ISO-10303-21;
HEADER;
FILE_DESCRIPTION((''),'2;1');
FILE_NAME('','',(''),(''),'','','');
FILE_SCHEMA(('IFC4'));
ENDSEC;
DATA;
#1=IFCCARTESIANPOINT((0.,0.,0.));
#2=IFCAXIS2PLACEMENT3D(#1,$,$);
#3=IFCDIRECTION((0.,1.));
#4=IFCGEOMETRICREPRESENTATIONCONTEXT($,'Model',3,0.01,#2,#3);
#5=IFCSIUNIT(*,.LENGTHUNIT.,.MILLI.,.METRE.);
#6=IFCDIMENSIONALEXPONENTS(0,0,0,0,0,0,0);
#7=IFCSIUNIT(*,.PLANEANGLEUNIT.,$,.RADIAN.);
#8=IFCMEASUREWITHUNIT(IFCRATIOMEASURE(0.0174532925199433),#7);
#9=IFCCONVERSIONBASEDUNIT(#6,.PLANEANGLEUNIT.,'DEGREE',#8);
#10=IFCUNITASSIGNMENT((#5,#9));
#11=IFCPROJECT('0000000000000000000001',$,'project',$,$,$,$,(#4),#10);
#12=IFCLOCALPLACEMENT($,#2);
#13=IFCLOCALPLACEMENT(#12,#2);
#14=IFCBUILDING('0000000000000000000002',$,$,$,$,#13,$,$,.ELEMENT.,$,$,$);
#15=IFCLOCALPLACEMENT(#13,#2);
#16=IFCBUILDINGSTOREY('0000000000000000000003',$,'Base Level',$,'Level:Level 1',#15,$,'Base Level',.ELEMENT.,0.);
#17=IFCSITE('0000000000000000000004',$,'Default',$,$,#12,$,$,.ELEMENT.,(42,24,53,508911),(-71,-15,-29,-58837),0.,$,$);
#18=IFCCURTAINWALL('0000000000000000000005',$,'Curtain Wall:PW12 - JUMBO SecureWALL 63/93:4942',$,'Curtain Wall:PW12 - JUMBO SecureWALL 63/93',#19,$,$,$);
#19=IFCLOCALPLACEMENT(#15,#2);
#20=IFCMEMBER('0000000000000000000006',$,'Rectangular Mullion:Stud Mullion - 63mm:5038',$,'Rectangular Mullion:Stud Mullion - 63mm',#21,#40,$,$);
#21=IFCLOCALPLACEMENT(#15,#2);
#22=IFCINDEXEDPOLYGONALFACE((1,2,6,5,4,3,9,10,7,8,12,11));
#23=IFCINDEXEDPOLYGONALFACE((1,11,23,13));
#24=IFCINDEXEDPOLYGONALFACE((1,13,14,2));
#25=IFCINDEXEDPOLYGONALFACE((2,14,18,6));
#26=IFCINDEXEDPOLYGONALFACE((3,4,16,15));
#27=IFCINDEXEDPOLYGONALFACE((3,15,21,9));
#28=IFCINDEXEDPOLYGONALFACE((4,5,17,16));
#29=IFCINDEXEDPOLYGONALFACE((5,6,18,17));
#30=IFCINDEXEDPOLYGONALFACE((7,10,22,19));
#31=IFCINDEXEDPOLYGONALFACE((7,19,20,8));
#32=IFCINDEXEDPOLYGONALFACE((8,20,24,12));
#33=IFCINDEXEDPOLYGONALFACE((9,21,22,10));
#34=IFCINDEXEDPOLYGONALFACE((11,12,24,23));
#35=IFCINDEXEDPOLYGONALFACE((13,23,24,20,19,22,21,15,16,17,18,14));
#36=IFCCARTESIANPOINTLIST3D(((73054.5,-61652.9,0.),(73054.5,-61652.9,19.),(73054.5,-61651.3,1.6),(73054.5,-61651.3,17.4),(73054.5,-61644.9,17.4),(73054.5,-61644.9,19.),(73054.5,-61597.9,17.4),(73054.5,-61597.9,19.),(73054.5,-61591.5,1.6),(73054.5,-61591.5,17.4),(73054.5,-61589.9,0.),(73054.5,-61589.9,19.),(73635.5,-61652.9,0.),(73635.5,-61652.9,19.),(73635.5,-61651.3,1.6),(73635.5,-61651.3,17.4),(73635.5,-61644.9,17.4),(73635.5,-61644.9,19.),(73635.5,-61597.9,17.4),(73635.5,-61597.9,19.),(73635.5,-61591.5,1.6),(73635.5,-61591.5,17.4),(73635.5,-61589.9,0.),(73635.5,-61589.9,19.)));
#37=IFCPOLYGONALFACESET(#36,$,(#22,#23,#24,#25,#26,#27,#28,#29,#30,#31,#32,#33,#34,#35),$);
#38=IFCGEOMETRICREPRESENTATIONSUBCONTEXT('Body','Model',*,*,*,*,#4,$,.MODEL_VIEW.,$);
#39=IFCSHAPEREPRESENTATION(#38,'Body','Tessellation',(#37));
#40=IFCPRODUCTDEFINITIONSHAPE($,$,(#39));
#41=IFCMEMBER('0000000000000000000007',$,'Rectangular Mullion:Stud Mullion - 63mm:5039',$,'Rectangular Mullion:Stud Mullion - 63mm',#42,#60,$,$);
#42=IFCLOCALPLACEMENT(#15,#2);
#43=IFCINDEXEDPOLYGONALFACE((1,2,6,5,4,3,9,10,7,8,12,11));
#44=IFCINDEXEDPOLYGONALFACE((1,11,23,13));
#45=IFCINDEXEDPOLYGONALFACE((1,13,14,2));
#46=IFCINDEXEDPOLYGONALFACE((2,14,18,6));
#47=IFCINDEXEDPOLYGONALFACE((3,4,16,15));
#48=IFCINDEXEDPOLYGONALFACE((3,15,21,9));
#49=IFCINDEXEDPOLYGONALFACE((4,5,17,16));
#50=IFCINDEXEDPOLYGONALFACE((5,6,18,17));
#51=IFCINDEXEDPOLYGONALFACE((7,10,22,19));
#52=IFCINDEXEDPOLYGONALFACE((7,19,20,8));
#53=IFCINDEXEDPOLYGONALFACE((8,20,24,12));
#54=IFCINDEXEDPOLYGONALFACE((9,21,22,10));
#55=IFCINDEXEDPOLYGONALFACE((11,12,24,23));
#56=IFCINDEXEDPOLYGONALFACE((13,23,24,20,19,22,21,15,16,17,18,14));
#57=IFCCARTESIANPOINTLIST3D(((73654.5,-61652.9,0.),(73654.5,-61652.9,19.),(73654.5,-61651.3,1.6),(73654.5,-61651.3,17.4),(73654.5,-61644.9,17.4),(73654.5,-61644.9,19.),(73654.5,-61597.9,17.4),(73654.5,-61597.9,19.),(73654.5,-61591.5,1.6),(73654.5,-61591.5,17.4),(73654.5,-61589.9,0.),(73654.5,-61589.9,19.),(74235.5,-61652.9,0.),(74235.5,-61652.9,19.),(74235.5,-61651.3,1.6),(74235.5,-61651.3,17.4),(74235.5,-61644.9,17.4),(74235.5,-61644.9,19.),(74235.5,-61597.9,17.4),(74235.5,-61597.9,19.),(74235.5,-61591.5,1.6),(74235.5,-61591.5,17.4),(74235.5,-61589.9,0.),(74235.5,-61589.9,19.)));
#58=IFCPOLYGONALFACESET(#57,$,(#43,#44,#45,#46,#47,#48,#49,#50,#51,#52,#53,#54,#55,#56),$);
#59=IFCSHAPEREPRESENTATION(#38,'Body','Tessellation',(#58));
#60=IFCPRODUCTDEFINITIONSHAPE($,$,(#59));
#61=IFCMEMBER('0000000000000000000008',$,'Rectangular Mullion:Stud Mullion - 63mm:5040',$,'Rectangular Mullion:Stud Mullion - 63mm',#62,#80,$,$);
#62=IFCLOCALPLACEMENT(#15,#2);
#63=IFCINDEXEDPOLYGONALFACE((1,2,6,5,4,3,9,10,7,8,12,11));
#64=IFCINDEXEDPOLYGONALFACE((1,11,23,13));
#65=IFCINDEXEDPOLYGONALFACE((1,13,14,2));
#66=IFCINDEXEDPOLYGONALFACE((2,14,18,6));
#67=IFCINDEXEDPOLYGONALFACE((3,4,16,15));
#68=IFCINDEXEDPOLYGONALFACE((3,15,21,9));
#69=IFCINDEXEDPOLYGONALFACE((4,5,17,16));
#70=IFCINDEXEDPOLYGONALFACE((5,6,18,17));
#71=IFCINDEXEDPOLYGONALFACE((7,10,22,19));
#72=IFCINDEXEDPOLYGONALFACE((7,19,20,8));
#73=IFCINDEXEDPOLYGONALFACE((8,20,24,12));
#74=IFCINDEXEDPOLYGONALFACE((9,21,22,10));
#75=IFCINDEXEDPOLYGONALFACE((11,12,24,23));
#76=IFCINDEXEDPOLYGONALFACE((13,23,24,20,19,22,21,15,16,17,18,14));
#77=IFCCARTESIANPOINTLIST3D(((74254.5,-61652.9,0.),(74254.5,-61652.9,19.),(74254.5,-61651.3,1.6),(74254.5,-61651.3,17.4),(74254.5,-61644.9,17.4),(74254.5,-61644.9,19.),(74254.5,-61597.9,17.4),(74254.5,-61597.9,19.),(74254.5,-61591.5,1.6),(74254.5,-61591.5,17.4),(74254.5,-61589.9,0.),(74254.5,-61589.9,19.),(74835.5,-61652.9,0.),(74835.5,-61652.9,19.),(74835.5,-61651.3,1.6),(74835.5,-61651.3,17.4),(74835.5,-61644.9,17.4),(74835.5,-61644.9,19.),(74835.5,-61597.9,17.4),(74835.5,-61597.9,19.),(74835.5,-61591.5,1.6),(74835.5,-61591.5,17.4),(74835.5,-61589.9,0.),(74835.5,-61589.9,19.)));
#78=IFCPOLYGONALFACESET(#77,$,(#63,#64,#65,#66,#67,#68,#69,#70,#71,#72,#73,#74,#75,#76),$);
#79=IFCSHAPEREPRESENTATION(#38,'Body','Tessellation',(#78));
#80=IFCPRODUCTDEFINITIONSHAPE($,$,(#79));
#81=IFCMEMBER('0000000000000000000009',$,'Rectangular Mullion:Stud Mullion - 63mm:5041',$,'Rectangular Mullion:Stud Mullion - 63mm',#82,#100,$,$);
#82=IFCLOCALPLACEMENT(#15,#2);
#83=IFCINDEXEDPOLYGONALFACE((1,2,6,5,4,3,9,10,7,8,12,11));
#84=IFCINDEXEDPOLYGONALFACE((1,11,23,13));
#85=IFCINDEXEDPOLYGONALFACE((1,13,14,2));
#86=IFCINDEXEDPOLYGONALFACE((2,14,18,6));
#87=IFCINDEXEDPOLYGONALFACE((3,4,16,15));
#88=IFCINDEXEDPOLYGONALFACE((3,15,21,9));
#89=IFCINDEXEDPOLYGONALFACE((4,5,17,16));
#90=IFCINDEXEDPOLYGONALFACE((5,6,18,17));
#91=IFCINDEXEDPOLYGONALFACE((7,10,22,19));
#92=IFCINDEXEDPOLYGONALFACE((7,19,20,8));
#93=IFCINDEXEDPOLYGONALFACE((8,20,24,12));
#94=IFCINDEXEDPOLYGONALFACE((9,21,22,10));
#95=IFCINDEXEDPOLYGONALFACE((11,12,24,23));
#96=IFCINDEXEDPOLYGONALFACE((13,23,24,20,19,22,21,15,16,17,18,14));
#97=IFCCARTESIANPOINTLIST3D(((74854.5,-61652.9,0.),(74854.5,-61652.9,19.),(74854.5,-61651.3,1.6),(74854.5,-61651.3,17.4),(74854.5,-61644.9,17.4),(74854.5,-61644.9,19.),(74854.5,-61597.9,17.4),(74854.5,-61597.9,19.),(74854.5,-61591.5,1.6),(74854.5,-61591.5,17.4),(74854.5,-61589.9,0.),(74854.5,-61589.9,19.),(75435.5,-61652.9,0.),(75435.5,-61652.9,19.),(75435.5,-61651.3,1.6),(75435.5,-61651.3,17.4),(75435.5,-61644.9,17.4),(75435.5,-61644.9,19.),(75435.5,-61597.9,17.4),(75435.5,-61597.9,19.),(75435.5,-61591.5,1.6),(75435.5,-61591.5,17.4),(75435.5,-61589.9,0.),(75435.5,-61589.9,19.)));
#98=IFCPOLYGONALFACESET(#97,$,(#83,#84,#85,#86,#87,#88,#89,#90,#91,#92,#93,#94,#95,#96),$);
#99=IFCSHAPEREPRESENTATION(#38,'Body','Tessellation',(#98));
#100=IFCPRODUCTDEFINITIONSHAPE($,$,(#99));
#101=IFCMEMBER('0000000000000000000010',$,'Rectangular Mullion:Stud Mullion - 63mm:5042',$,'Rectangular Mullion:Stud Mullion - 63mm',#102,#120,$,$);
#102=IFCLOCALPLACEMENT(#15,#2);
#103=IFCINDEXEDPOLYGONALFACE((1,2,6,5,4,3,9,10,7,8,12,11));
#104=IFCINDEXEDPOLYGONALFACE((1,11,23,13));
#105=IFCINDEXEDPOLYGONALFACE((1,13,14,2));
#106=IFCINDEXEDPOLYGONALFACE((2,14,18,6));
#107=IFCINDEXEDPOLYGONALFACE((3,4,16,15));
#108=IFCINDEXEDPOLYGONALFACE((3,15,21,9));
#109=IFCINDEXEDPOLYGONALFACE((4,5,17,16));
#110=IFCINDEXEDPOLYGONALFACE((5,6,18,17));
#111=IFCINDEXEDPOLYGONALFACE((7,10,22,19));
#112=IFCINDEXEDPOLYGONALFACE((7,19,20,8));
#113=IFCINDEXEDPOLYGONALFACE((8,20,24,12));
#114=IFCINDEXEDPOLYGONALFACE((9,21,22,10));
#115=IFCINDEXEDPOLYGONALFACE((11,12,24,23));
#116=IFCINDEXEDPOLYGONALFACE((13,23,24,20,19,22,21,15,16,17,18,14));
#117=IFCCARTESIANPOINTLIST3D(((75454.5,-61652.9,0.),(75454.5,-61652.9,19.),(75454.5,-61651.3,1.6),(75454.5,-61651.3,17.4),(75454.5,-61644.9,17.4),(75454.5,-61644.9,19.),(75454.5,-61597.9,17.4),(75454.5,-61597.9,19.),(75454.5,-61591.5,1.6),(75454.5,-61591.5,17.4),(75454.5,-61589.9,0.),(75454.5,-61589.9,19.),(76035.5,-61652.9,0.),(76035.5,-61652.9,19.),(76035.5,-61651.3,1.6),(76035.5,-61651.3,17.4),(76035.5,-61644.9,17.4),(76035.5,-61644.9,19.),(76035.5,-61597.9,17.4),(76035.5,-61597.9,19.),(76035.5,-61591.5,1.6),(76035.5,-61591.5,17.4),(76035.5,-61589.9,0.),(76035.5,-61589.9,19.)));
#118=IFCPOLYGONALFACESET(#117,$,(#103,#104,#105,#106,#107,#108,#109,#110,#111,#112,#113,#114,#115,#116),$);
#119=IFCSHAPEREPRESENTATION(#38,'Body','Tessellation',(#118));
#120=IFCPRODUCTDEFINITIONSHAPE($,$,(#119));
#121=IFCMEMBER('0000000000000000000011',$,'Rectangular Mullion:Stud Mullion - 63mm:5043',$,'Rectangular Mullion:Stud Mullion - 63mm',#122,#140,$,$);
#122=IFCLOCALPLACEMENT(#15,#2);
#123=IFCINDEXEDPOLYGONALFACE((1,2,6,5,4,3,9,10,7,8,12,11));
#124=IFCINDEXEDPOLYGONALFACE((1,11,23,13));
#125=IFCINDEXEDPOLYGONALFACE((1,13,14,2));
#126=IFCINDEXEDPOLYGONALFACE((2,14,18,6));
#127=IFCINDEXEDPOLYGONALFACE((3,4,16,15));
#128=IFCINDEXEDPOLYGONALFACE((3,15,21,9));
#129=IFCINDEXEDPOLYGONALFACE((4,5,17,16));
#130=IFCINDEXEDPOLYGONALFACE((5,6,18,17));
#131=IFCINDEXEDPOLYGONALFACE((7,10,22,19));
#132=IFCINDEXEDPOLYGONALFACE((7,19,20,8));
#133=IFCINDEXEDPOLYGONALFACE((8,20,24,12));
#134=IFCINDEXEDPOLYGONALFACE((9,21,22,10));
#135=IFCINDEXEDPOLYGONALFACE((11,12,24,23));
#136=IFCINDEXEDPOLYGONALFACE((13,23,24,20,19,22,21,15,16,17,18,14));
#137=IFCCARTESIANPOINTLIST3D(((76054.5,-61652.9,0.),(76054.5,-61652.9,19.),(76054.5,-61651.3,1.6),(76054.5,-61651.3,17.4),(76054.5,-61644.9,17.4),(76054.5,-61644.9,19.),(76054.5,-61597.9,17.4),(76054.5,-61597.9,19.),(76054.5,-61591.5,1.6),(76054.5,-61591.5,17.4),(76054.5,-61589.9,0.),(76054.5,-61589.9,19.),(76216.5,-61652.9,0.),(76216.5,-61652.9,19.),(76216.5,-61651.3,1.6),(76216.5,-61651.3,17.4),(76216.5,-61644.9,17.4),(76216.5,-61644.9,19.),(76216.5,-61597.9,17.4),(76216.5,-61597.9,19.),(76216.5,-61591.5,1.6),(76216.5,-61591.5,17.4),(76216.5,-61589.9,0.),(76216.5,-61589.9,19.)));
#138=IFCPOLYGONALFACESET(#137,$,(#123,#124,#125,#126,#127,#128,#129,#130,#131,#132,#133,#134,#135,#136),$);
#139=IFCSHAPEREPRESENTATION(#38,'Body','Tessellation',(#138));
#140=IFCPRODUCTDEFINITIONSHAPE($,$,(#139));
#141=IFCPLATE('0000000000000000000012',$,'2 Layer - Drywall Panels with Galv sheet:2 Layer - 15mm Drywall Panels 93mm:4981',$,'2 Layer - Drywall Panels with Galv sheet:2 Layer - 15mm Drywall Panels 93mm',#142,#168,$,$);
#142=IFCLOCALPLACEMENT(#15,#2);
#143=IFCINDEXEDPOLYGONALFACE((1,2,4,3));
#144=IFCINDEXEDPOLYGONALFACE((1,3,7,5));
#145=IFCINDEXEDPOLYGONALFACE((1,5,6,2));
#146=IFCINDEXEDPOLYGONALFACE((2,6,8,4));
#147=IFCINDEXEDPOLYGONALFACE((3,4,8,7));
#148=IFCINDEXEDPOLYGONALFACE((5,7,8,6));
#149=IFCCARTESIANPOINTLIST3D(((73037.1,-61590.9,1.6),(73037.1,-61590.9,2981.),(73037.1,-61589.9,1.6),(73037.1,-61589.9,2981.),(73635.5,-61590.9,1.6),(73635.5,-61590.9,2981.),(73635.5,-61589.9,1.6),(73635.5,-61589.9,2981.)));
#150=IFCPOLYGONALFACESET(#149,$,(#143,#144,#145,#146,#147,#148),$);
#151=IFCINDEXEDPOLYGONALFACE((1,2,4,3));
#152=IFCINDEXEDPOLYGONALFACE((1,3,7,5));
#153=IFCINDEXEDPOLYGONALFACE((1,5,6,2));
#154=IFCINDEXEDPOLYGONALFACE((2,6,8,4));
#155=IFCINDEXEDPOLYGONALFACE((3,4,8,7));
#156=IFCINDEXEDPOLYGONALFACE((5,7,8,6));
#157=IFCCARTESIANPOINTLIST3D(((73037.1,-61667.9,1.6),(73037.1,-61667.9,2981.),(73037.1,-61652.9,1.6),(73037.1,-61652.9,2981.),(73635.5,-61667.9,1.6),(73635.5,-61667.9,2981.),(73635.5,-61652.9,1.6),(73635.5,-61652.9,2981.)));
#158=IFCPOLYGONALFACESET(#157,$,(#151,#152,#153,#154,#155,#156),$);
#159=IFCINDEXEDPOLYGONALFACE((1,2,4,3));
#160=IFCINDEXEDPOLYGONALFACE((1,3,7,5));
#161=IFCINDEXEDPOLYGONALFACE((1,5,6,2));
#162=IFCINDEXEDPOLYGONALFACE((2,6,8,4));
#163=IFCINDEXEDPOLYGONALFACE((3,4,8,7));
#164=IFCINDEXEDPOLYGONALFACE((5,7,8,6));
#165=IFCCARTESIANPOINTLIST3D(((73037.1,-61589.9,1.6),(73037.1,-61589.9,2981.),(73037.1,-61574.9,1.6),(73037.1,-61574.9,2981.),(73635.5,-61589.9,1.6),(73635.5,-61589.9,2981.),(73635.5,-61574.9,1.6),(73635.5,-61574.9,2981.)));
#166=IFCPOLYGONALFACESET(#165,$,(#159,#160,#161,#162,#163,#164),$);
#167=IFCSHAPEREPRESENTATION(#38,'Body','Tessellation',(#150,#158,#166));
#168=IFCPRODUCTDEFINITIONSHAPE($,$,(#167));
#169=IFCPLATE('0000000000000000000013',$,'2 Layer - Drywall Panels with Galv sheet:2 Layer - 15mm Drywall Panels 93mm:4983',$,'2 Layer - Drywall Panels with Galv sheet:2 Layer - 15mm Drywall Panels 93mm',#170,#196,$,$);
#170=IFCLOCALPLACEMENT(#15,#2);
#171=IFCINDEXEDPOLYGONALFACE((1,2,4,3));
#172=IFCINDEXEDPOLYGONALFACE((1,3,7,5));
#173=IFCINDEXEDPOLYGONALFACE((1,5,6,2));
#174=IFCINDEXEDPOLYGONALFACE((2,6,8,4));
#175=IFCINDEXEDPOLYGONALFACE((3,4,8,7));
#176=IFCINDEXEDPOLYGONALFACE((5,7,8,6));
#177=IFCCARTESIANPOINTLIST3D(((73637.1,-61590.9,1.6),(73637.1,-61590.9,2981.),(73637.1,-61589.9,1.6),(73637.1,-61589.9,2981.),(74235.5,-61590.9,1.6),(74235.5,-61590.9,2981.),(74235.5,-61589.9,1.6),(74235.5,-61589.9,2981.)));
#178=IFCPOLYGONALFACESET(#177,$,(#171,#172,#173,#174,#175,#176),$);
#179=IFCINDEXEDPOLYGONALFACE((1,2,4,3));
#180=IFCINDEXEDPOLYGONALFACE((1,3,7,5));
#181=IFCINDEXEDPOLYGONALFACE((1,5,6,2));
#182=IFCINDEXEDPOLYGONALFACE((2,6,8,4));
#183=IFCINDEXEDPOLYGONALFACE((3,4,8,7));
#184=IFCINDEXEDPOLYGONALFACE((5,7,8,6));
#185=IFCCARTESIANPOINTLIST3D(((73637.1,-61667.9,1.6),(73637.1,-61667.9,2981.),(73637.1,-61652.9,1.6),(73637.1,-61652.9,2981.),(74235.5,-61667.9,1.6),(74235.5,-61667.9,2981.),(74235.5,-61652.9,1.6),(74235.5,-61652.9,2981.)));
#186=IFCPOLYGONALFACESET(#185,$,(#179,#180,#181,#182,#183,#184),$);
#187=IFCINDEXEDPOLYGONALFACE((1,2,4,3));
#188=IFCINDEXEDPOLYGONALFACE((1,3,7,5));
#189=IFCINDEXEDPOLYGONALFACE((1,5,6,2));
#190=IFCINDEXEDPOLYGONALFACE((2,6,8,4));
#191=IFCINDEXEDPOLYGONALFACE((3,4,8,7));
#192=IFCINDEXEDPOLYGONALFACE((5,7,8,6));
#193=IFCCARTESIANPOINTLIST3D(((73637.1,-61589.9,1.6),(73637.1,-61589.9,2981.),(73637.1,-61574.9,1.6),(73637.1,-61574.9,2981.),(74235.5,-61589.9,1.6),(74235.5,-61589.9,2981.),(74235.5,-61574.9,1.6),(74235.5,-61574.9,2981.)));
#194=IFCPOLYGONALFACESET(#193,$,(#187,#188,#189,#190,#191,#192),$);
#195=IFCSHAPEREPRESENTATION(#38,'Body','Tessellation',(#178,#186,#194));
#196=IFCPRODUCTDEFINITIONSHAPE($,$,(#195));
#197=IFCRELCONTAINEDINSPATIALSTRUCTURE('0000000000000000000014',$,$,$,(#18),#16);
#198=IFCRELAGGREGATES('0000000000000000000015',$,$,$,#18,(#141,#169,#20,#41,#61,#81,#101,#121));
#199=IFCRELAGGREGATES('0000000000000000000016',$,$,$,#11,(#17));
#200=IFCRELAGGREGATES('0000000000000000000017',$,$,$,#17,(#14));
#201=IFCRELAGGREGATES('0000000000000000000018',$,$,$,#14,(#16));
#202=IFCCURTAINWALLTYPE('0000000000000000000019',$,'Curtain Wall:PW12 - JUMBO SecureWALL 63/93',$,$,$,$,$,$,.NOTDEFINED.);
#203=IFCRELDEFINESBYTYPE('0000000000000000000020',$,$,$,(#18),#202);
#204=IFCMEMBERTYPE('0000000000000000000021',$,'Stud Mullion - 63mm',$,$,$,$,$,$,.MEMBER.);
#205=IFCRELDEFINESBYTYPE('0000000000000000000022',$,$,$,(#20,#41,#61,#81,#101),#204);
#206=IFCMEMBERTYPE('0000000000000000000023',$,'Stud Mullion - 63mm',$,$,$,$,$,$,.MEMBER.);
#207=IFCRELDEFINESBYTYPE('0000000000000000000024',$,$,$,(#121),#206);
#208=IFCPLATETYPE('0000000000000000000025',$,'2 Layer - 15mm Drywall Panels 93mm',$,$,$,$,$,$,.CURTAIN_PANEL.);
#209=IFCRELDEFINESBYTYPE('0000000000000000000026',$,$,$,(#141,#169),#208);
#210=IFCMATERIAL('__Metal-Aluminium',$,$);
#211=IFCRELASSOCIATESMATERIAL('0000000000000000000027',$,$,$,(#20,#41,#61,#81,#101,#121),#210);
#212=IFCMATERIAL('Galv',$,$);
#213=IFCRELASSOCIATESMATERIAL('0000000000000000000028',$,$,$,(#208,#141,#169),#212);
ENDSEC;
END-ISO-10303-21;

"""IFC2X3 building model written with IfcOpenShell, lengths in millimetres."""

from ifc_helpers import new_model, entity, si_unit, converted_unit, direction, frame, frame_2d, origin, origin_2d_with_axis, place, context, subcontext, project, spatial, polyline, rectangle, outline, extrude, source, transform, mapped, material, type_object, type_shapes, element, aggregate, save


model = new_model("IFC2X3")

# Units and contexts
model_context = context("Model", 3, precision=0.01, world=origin(), true_north=direction((0.0, 1.0)))
body_context = subcontext(model_context, "Body", "Model", "MODEL_VIEW")
ifc_project = project(units=[si_unit("LENGTHUNIT", "METRE", prefix="MILLI"), converted_unit("PLANEANGLEUNIT", "DEGREE", entity("IfcRatioMeasure", 0.0174532925199433), si_unit("PLANEANGLEUNIT", "RADIAN"), dimensions=[0, 0, 0, 0, 0, 0, 0])], contexts=[model_context])

# Site, building, storey
site_placement = place(None, origin())
site = spatial("IfcSite", under=ifc_project, at=site_placement, Name="Default", CompositionType="ELEMENT", RefLatitude=(42, 24, 53, 508911), RefLongitude=(-71, -15, -29, -58837), RefElevation=0.0)
building_placement = place(site_placement, origin())
building = spatial("IfcBuilding", under=site, at=building_placement, CompositionType="ELEMENT")
storey_placement = place(building_placement, origin())
storey = spatial("IfcBuildingStorey", under=building, at=storey_placement, Name="Base Level", ObjectType="Level:Level 1", LongName="Base Level", CompositionType="ELEMENT", Elevation=0.0)

# Curtain wall, members, plates
curtain_wall_type = type_object("IfcCurtainWallType", Name="Curtain Wall:PW12 - JUMBO SecureWALL 63/93", PredefinedType="NOTDEFINED")
curtain_wall_placement = place(building_placement, origin())
curtain_wall = element("IfcCurtainWall", 1, at=curtain_wall_placement, inside=storey, type_object=curtain_wall_type, Name="Curtain Wall:PW12 - JUMBO SecureWALL 63/93:4942", ObjectType="Curtain Wall:PW12 - JUMBO SecureWALL 63/93")
ifc_material_1 = material(Name="__Metal-Aluminium")
member_type_1 = type_object("IfcMemberType", Name="Stud Mullion - 63mm", PredefinedType="MEMBER")
shared_shape_1 = source(origin(), body_context, "Body", "SweptSolid", [
    extrude(outline(polyline([(23.5, -6.6), (31.5, -6.6), (31.5, 12.4), (-31.5, 12.4), (-31.5, -6.6), (-23.5, -6.6), (-23.5, -5.0), (-29.9, -5.0), (-29.9, 10.8), (29.9, 10.8), (29.9, -5.0), (23.5, -5.0), (23.5, -6.6)])), frame((-12.4, 0.0, -581.0), z_axis=(0.0, 0.0, 1.0), x_axis=(0.0, -1.0, 0.0)), (0.0, 0.0, 1.0), 581.0),
])
type_shapes(member_type_1, [shared_shape_1])
member_1_placement = place(building_placement, frame((73054.5, -61621.4, 0.0), z_axis=(-1.0, 0.0, 0.0), x_axis=(0.0, 0.0, -1.0)))
member_1 = element("IfcMember", 2, at=member_1_placement, type_object=member_type_1, material=ifc_material_1, Name="Rectangular Mullion:Stud Mullion - 63mm:5038", ObjectType="Rectangular Mullion:Stud Mullion - 63mm", context=body_context, shape_type="MappedRepresentation", body=[
    mapped(shared_shape_1, transform((0.0, 0.0, 0.0), scale=1.0)),
])
member_2_placement = place(building_placement, frame((73654.5, -61621.4, 0.0), z_axis=(-1.0, 0.0, 0.0), x_axis=(0.0, 0.0, -1.0)))
member_2 = element("IfcMember", 3, at=member_2_placement, type_object=member_type_1, material=ifc_material_1, Name="Rectangular Mullion:Stud Mullion - 63mm:5039", ObjectType="Rectangular Mullion:Stud Mullion - 63mm", context=body_context, shape_type="MappedRepresentation", body=[
    mapped(shared_shape_1, transform((0.0, 0.0, 0.0), scale=1.0)),
])
member_3_placement = place(building_placement, frame((74254.5, -61621.4, 0.0), z_axis=(-1.0, 0.0, 0.0), x_axis=(0.0, 0.0, -1.0)))
member_3 = element("IfcMember", 4, at=member_3_placement, type_object=member_type_1, material=ifc_material_1, Name="Rectangular Mullion:Stud Mullion - 63mm:5040", ObjectType="Rectangular Mullion:Stud Mullion - 63mm", context=body_context, shape_type="MappedRepresentation", body=[
    mapped(shared_shape_1, transform((0.0, 0.0, 0.0), scale=1.0)),
])
member_4_placement = place(building_placement, frame((74854.5, -61621.4, 0.0), z_axis=(-1.0, 0.0, 0.0), x_axis=(0.0, 0.0, -1.0)))
member_4 = element("IfcMember", 5, at=member_4_placement, type_object=member_type_1, material=ifc_material_1, Name="Rectangular Mullion:Stud Mullion - 63mm:5041", ObjectType="Rectangular Mullion:Stud Mullion - 63mm", context=body_context, shape_type="MappedRepresentation", body=[
    mapped(shared_shape_1, transform((0.0, 0.0, 0.0), scale=1.0)),
])
member_5_placement = place(building_placement, frame((75454.5, -61621.4, 0.0), z_axis=(-1.0, 0.0, 0.0), x_axis=(0.0, 0.0, -1.0)))
member_5 = element("IfcMember", 6, at=member_5_placement, type_object=member_type_1, material=ifc_material_1, Name="Rectangular Mullion:Stud Mullion - 63mm:5042", ObjectType="Rectangular Mullion:Stud Mullion - 63mm", context=body_context, shape_type="MappedRepresentation", body=[
    mapped(shared_shape_1, transform((0.0, 0.0, 0.0), scale=1.0)),
])
member_type_2 = type_object("IfcMemberType", Name="Stud Mullion - 63mm", PredefinedType="MEMBER")
shared_shape_2 = source(origin(), body_context, "Body", "SweptSolid", [
    extrude(outline(polyline([(23.5, -6.6), (31.5, -6.6), (31.5, 12.4), (-31.5, 12.4), (-31.5, -6.6), (-23.5, -6.6), (-23.5, -5.0), (-29.9, -5.0), (-29.9, 10.8), (29.9, 10.8), (29.9, -5.0), (23.5, -5.0), (23.5, -6.6)])), frame((-12.4, 0.0, -162.0), z_axis=(0.0, 0.0, 1.0), x_axis=(0.0, -1.0, 0.0)), (0.0, 0.0, 1.0), 162.0),
])
type_shapes(member_type_2, [shared_shape_2])
member_6_placement = place(building_placement, frame((76054.5, -61621.4, 0.0), z_axis=(-1.0, 0.0, 0.0), x_axis=(0.0, 0.0, -1.0)))
member_6 = element("IfcMember", 7, at=member_6_placement, type_object=member_type_2, material=ifc_material_1, Name="Rectangular Mullion:Stud Mullion - 63mm:5043", ObjectType="Rectangular Mullion:Stud Mullion - 63mm", context=body_context, shape_type="MappedRepresentation", body=[
    mapped(shared_shape_2, transform((0.0, 0.0, 0.0), scale=1.0)),
])
ifc_material_2 = material(Name="Galv")
plate_type_1 = type_object("IfcPlateType", Name="2 Layer - 15mm Drywall Panels 93mm", PredefinedType="CURTAIN_PANEL", material=ifc_material_2)
shared_shape_3 = source(origin(), body_context, "Body", "SweptSolid", [
    extrude(rectangle(XDim=598.4, YDim=1.0, at=origin_2d_with_axis()), frame((0.0, 31.0, 0.0), z_axis=(0.0, 0.0, 1.0), x_axis=(-1.0, 0.0, 0.0)), (0.0, 0.0, 1.0), 2979.4),
    extrude(rectangle(XDim=598.4, YDim=15.0, at=frame_2d((0.0, 0.0), x_axis=(1.0, 0.0))), frame((0.0, -39.0, 0.0), z_axis=(0.0, 0.0, 1.0), x_axis=(-1.0, 0.0, 0.0)), (0.0, 0.0, 1.0), 2979.4),
    extrude(rectangle(XDim=15.0, YDim=598.4, at=frame_2d((0.0, 0.0), x_axis=(1.0, 0.0))), frame((0.0, 39.0, 0.0), z_axis=(0.0, 0.0, 1.0), x_axis=(0.0, 1.0, 0.0)), (0.0, 0.0, 1.0), 2979.4),
])
type_shapes(plate_type_1, [shared_shape_3])
plate_1_placement = place(curtain_wall_placement, frame((73336.3, -61621.4, 1.6)))
plate_1 = element("IfcPlate", 8, at=plate_1_placement, type_object=plate_type_1, material=ifc_material_2, Name="2 Layer - Drywall Panels with Galv sheet:2 Layer - 15mm Drywall Panels 93mm:4981", ObjectType="2 Layer - Drywall Panels with Galv sheet:2 Layer - 15mm Drywall Panels 93mm", context=body_context, shape_type="MappedRepresentation", body=[
    mapped(shared_shape_3, transform((0.0, 0.0, 0.0), scale=1.0)),
])
plate_2_placement = place(curtain_wall_placement, frame((73936.3, -61621.4, 1.6)))
plate_2 = element("IfcPlate", 9, at=plate_2_placement, type_object=plate_type_1, material=ifc_material_2, Name="2 Layer - Drywall Panels with Galv sheet:2 Layer - 15mm Drywall Panels 93mm:4983", ObjectType="2 Layer - Drywall Panels with Galv sheet:2 Layer - 15mm Drywall Panels 93mm", context=body_context, shape_type="MappedRepresentation", body=[
    mapped(shared_shape_3, transform((0.0, 0.0, 0.0), scale=1.0)),
])
aggregate(curtain_wall, [plate_1, plate_2, member_1, member_2, member_3, member_4, member_5, member_6])

save(model, "model.ifc")
